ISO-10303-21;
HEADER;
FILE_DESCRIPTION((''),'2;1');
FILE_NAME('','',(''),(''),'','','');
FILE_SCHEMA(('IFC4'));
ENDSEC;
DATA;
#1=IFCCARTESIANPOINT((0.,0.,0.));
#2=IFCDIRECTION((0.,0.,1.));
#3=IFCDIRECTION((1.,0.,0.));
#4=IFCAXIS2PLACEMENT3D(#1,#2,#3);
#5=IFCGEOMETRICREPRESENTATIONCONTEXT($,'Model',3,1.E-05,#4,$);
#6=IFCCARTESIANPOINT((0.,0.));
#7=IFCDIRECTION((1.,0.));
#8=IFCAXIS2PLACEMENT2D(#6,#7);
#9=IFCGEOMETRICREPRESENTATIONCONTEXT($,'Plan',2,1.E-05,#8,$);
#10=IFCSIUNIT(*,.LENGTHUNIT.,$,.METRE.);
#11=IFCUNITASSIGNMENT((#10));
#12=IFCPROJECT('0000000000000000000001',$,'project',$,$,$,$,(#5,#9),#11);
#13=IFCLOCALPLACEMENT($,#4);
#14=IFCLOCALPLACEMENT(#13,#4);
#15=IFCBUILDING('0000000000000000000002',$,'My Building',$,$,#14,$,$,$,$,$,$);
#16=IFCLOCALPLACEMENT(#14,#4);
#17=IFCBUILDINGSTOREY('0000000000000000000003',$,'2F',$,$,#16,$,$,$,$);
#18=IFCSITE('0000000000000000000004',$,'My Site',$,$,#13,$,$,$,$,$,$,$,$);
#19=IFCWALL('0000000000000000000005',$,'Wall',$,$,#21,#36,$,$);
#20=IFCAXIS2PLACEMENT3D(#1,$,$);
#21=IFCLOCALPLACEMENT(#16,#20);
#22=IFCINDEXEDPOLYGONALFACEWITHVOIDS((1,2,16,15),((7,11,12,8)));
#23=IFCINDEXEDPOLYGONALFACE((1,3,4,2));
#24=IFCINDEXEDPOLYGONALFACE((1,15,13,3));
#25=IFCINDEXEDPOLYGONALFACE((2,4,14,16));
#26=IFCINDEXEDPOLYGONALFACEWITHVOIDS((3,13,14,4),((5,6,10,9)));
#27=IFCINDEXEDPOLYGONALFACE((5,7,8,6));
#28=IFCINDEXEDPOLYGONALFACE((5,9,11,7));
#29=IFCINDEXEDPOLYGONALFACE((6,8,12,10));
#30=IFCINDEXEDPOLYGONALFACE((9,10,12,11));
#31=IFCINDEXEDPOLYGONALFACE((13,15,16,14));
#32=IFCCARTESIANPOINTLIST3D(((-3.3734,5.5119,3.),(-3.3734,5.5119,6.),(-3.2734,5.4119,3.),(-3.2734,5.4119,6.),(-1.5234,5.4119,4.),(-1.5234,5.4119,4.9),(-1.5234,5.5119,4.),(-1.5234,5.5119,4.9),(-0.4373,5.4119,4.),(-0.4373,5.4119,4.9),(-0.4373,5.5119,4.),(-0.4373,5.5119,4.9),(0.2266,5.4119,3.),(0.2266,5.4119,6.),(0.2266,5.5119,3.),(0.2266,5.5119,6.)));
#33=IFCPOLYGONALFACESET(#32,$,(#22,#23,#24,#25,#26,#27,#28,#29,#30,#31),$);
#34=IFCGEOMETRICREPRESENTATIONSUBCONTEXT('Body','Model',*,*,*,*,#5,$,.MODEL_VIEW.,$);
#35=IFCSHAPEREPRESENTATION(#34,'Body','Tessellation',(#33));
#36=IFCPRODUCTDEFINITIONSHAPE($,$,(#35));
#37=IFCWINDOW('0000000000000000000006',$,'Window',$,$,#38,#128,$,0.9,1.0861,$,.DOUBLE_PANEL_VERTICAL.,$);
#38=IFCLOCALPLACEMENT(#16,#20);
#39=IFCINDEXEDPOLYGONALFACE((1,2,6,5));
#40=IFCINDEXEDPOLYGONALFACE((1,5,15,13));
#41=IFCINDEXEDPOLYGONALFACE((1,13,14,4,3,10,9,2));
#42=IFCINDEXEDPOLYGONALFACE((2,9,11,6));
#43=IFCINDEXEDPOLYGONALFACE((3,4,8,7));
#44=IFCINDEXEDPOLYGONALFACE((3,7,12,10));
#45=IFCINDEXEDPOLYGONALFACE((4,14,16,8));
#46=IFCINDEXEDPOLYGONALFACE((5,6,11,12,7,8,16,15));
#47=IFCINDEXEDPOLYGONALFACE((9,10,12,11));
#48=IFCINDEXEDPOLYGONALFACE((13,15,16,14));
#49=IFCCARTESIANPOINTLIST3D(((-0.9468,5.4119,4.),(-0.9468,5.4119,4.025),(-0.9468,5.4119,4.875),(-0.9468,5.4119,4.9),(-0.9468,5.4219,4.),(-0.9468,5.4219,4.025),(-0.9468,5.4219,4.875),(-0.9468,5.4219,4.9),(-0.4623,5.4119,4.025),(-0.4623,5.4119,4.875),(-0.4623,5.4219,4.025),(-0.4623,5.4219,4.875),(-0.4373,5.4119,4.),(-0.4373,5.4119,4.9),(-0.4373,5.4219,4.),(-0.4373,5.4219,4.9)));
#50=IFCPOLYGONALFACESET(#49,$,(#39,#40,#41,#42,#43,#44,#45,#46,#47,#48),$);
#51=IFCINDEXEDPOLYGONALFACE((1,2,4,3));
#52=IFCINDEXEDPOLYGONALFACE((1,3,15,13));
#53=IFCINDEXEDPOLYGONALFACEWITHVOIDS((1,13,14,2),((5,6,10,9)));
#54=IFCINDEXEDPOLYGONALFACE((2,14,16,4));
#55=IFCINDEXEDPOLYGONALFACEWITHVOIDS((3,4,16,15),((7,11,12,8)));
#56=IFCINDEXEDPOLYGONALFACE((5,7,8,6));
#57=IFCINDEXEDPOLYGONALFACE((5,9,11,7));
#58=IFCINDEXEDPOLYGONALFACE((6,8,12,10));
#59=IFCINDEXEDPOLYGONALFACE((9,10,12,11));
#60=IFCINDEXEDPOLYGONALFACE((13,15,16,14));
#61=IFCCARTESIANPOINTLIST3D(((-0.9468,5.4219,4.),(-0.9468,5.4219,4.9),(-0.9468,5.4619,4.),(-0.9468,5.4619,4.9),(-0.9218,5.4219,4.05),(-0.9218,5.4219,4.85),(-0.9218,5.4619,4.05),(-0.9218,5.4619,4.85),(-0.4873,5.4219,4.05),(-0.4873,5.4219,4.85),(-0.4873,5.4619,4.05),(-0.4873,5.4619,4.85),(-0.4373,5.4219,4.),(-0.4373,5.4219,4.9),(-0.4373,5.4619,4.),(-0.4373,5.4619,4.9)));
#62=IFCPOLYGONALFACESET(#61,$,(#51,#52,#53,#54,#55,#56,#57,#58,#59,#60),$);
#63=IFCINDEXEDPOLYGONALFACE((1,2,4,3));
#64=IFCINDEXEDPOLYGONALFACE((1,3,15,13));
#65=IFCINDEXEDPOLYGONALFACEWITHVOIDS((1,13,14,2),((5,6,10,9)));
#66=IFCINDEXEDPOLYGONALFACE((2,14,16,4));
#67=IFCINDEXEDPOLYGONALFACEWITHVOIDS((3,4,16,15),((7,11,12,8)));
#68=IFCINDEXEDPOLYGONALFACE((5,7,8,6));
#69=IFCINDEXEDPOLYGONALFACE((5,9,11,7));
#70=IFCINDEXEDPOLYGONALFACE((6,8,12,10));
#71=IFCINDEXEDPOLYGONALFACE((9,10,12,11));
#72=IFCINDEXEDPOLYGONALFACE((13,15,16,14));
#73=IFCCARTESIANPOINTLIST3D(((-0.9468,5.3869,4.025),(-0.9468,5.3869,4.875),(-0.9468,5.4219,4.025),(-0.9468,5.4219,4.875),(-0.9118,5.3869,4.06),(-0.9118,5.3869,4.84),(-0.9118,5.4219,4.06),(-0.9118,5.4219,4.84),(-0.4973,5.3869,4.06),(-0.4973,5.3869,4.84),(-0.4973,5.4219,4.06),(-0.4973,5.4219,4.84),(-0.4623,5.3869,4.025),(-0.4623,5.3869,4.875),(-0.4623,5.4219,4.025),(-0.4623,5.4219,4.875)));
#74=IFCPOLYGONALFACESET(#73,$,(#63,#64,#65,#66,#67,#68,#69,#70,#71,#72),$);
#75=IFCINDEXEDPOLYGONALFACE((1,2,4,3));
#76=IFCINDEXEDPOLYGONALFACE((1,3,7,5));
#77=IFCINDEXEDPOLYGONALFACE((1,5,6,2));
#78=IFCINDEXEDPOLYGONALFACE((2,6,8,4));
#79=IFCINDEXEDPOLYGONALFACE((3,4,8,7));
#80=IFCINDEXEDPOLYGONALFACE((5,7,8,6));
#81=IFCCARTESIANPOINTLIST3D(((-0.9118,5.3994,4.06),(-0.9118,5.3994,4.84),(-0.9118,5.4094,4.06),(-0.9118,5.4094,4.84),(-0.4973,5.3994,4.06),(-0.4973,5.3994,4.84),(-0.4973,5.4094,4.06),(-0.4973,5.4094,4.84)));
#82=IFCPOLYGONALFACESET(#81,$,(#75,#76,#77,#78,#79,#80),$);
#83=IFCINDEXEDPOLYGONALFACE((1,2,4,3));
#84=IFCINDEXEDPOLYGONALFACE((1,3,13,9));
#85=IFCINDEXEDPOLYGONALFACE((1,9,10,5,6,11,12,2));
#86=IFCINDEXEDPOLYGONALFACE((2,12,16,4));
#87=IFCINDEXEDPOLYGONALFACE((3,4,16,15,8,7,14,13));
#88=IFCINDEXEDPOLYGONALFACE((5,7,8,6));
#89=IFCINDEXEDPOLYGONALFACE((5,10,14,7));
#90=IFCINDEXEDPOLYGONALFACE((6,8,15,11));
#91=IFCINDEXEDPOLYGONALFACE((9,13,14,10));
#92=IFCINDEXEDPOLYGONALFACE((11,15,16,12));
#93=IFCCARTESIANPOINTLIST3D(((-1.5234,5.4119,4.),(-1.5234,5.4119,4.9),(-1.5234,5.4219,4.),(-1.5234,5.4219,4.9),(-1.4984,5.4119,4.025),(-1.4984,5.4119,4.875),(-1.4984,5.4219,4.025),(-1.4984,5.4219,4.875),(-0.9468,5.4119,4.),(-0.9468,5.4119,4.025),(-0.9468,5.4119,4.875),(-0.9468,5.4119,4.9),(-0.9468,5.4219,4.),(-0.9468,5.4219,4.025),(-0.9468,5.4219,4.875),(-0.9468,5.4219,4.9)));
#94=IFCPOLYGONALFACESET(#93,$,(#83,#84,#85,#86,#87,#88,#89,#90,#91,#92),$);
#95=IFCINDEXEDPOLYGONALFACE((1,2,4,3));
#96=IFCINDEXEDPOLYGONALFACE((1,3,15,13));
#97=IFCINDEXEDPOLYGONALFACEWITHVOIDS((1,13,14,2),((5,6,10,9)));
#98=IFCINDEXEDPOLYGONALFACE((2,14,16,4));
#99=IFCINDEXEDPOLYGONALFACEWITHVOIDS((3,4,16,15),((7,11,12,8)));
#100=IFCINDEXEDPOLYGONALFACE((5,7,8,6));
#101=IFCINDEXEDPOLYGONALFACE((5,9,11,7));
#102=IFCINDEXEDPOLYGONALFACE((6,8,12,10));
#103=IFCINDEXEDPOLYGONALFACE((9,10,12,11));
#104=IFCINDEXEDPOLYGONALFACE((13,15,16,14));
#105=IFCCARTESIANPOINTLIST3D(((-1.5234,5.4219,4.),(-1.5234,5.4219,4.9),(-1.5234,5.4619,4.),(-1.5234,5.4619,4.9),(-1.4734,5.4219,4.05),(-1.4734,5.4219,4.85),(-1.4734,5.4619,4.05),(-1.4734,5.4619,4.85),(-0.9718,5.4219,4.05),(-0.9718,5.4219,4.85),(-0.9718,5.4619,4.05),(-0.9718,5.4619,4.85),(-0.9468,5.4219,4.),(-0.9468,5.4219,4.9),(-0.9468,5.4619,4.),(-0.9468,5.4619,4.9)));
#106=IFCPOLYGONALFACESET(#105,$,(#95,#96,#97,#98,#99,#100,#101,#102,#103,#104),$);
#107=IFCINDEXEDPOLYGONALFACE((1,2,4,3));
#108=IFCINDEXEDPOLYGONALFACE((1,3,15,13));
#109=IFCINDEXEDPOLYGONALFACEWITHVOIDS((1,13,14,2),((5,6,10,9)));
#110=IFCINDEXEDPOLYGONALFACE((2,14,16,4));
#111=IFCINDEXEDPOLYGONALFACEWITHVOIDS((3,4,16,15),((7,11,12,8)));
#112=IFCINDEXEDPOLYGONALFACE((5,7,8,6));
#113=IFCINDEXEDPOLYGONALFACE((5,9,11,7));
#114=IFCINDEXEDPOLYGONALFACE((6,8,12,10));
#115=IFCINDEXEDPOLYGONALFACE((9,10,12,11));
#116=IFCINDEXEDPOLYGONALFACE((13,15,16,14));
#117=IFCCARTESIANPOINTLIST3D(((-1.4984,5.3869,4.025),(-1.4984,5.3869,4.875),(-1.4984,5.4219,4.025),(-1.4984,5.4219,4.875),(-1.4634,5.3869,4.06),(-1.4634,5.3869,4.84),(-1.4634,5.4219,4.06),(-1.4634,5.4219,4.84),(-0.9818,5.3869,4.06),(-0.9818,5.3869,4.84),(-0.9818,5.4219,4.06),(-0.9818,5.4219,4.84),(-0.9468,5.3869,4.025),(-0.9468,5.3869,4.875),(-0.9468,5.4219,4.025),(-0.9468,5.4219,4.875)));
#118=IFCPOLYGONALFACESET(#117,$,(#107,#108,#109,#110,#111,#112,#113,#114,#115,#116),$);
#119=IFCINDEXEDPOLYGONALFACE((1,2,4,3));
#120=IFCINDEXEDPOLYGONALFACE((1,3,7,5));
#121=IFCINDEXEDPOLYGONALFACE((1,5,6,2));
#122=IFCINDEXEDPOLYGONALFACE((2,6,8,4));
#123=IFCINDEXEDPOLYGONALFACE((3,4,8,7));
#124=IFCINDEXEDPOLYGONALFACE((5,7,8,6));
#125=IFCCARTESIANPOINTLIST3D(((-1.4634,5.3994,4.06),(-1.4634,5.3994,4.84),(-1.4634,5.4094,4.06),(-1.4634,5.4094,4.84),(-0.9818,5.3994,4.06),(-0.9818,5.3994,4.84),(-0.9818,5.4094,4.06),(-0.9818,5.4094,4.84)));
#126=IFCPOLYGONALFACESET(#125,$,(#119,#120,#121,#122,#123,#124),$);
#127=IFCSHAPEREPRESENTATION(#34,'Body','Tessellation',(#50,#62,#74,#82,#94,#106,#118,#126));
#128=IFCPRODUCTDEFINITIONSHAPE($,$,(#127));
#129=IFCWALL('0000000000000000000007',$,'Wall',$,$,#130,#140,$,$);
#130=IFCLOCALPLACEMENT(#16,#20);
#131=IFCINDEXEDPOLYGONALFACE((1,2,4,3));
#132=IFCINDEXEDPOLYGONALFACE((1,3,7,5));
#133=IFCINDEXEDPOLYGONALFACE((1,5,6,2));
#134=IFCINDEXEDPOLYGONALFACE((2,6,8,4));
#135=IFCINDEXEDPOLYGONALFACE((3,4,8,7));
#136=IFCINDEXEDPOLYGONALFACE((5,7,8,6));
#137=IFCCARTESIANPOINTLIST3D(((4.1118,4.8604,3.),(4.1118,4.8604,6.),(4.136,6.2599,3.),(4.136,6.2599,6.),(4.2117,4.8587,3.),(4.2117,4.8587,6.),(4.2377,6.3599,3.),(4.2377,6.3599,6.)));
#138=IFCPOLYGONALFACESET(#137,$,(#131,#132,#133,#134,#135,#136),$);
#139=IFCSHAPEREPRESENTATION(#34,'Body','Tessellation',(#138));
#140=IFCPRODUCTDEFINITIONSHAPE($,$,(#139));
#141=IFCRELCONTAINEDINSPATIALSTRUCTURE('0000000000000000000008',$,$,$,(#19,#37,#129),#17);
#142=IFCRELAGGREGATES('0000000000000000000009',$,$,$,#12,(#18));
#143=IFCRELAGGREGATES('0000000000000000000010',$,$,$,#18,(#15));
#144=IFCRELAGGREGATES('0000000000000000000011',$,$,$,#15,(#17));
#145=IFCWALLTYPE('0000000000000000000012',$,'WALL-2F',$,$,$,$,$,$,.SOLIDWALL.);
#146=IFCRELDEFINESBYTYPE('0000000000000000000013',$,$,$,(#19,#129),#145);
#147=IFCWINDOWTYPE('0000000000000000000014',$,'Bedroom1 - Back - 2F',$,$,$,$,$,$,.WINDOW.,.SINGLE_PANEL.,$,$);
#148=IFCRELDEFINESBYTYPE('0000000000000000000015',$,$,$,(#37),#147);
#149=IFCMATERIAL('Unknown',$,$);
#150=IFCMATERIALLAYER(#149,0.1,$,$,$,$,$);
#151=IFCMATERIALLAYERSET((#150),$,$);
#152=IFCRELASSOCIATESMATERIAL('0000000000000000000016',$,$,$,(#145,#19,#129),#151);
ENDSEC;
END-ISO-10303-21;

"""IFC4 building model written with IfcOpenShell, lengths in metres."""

from ifc_helpers import new_model, entity, si_unit, frame, origin_with_axes, origin_2d_with_axis, place, context, subcontext, project, spatial, line, indexed_curve, outline, extrude, shape, source, transform, mapped, material, layer, layer_set, layer_usage, type_object, type_shapes, element, fill, save


model = new_model("IFC4")

# Units and contexts
model_context = context("Model", 3, precision=1e-05, world=origin_with_axes())
plan_context = context("Plan", 2, precision=1e-05, world=origin_2d_with_axis())
body_context_1 = subcontext(model_context, "Body", "Model", "MODEL_VIEW")
body_context_2 = subcontext(plan_context, "Body", "Plan", "PLAN_VIEW")
ifc_project = project(units=[si_unit("LENGTHUNIT", "METRE")], contexts=[model_context, plan_context])

# Site, building, storey
site_placement = place(None, origin_with_axes())
site = spatial("IfcSite", under=ifc_project, at=site_placement, Name="My Site")
building_placement = place(site_placement, origin_with_axes())
building = spatial("IfcBuilding", under=site, at=building_placement, Name="My Building")
storey_placement = place(building_placement, origin_with_axes())
storey = spatial("IfcBuildingStorey", under=building, at=storey_placement, Name="2F")

# Shared definitions
ifc_material = material(Name="Unknown")

# Shared definitions
ifc_layer = layer(ifc_material, 0.1)
ifc_layer_set = layer_set([ifc_layer])
wall_type = type_object("IfcWallType", Name="WALL-2F", PredefinedType="SOLIDWALL", material=ifc_layer_set)

# Wall, opening, window
ifc_layer_usage_1 = layer_usage(ifc_layer_set, "AXIS2", "POSITIVE", 0.0)
wall_1_placement = place(storey_placement, frame((0.2266, 5.5119, 3.0), z_axis=(0.0, 0.0, 1.0), x_axis=(-1.0, 0.0, 0.0)))
wall_1 = element("IfcWall", 1, at=wall_1_placement, inside=storey, type_object=wall_type, material=ifc_layer_usage_1, Name="Wall", context=body_context_1, shape_type="SweptSolid", body=[
    extrude(outline(indexed_curve([(0.0, 0.0), (0.0, 0.1), (3.5, 0.1), (3.6, 0.0)], segments=[line(1, 2, 3, 4, 1)])), origin_with_axes(), (0.0, 0.0, 1.0), 3.0),
])
shared_shape_1 = source(origin_with_axes(), body_context_1, "Body", "SweptSolid", [
    extrude(outline(indexed_curve([(0.0, 0.0), (1.0861, 0.0), (1.0861, 0.9), (0.0, 0.9)], segments=[line(1, 2, 3, 4, 1)])), frame((0.0, -0.6, 0.0), z_axis=(0.0, -1.0, 0.0), x_axis=(1.0, 0.0, 0.0)), (0.0, 0.0, -1.0), 1.2),
])
opening_1_placement = place(wall_1_placement, frame((0.6639, 0.0, 1.0), z_axis=(0.0, 0.0, 1.0), x_axis=(1.0, 0.0, 0.0)))
opening_1 = element("IfcOpeningElement", 2, at=opening_1_placement, cuts=wall_1, PredefinedType="OPENING", context=body_context_1, shape_type="MappedRepresentation", body=[
    mapped(shared_shape_1, transform((0.0, 0.0, 0.0), x_axis=(1.0, 0.0, 0.0), y_axis=(0.0, 1.0, 0.0), z_axis=(0.0, 0.0, 1.0), scale=1.0)),
])
window_type_1 = type_object("IfcWindowType", Name="Bedroom1 - Back - 2F", PartitioningType="SINGLE_PANEL", PredefinedType="WINDOW")
shared_shape_2 = source(origin_with_axes(), body_context_1, "Body", "SweptSolid", [
    extrude(outline(indexed_curve([(0.5096, 0.0), (0.0, 0.0), (0.0, 0.9), (0.5096, 0.9), (0.5096, 0.875), (0.025, 0.875), (0.025, 0.025), (0.5096, 0.025)], segments=[line(1, 2, 3, 4, 5, 6, 7, 8, 1)])), frame((0.0, 0.09, 0.0), z_axis=(0.0, -1.0, 0.0), x_axis=(1.0, 0.0, 0.0)), (0.0, 0.0, -1.0), 0.01),
    extrude(outline(indexed_curve([(0.0, 0.0), (0.5096, 0.0), (0.5096, 0.9), (0.0, 0.9)], segments=[line(1, 2, 3, 4, 1)]), holes=[indexed_curve([(0.05, 0.05), (0.4846, 0.05), (0.4846, 0.85), (0.05, 0.85)], segments=[line(1, 2, 3, 4, 1)])]), frame((0.0, 0.05, 0.0), z_axis=(0.0, -1.0, 0.0), x_axis=(1.0, 0.0, 0.0)), (0.0, 0.0, -1.0), 0.04),
    extrude(outline(indexed_curve([(0.0, 0.0), (0.4846, 0.0), (0.4846, 0.85), (0.0, 0.85)], segments=[line(1, 2, 3, 4, 1)]), holes=[indexed_curve([(0.035, 0.035), (0.4496, 0.035), (0.4496, 0.815), (0.035, 0.815)], segments=[line(1, 2, 3, 4, 1)])]), frame((0.025, 0.09, 0.025), z_axis=(0.0, -1.0, 0.0), x_axis=(1.0, 0.0, 0.0)), (0.0, 0.0, -1.0), 0.035),
    extrude(outline(indexed_curve([(0.035, 0.035), (0.4496, 0.035), (0.4496, 0.815), (0.035, 0.815)], segments=[line(1, 2, 3, 4, 1)])), frame((0.025, 0.1025, 0.025), z_axis=(0.0, -1.0, 0.0), x_axis=(1.0, 0.0, 0.0)), (0.0, 0.0, -1.0), 0.01),
    extrude(outline(indexed_curve([(0.0, 0.9), (0.5766, 0.9), (0.5766, 0.0), (0.0, 0.0), (0.0, 0.025), (0.5516, 0.025), (0.5516, 0.875), (0.0, 0.875)], segments=[line(1, 2, 3, 4, 5, 6, 7, 8, 1)])), frame((0.5096, 0.09, 0.0), z_axis=(0.0, -1.0, 0.0), x_axis=(1.0, 0.0, 0.0)), (0.0, 0.0, -1.0), 0.01),
    extrude(outline(indexed_curve([(0.0, 0.0), (0.5766, 0.0), (0.5766, 0.9), (0.0, 0.9)], segments=[line(1, 2, 3, 4, 1)]), holes=[indexed_curve([(0.025, 0.05), (0.5266, 0.05), (0.5266, 0.85), (0.025, 0.85)], segments=[line(1, 2, 3, 4, 1)])]), frame((0.5096, 0.05, 0.0), z_axis=(0.0, -1.0, 0.0), x_axis=(1.0, 0.0, 0.0)), (0.0, 0.0, -1.0), 0.04),
    extrude(outline(indexed_curve([(0.0, 0.0), (0.5516, 0.0), (0.5516, 0.85), (0.0, 0.85)], segments=[line(1, 2, 3, 4, 1)]), holes=[indexed_curve([(0.035, 0.035), (0.5166, 0.035), (0.5166, 0.815), (0.035, 0.815)], segments=[line(1, 2, 3, 4, 1)])]), frame((0.5096, 0.09, 0.025), z_axis=(0.0, -1.0, 0.0), x_axis=(1.0, 0.0, 0.0)), (0.0, 0.0, -1.0), 0.035),
    extrude(outline(indexed_curve([(0.035, 0.035), (0.5166, 0.035), (0.5166, 0.815), (0.035, 0.815)], segments=[line(1, 2, 3, 4, 1)])), frame((0.5096, 0.1025, 0.025), z_axis=(0.0, -1.0, 0.0), x_axis=(1.0, 0.0, 0.0)), (0.0, 0.0, -1.0), 0.01),
])
shared_shape_3 = source(origin_with_axes(), body_context_2, "Body", "Curve2D", [
    entity("IfcIndexedPolyCurve", entity("IfcCartesianPointList2D", [[0.05, 0.05], [0.4846, 0.05]])),
    entity("IfcIndexedPolyCurve", entity("IfcCartesianPointList2D", [[0.0, 0.1], [0.025, 0.1], [0.025, 0.09], [0.05, 0.09], [0.05, 0.05], [0.0, 0.05]]), [entity("IfcLineIndex", [1, 2, 3, 4, 5, 6, 1])]),
    entity("IfcIndexedPolyCurve", entity("IfcCartesianPointList2D", [[0.5096, 0.1], [0.5096, 0.1], [0.5096, 0.09], [0.4846, 0.09], [0.4846, 0.05], [0.5096, 0.05]])),
    entity("IfcIndexedPolyCurve", entity("IfcCartesianPointList2D", [[0.025, 0.09], [0.06, 0.09], [0.06, 0.125], [0.025, 0.125]]), [entity("IfcLineIndex", [1, 2, 3, 4, 1])]),
    entity("IfcIndexedPolyCurve", entity("IfcCartesianPointList2D", [[0.5096, 0.09], [0.4746, 0.09], [0.4746, 0.125], [0.5096, 0.125]]), [entity("IfcLineIndex", [1, 2, 3, 4, 1])]),
    entity("IfcIndexedPolyCurve", entity("IfcCartesianPointList2D", [[0.06, 0.09], [0.4746, 0.09]])),
    entity("IfcIndexedPolyCurve", entity("IfcCartesianPointList2D", [[0.06, 0.125], [0.4746, 0.125]])),
    entity("IfcIndexedPolyCurve", entity("IfcCartesianPointList2D", [[0.06, 0.1075], [0.4746, 0.1075]])),
    entity("IfcIndexedPolyCurve", entity("IfcCartesianPointList2D", [[0.5346, 0.05], [1.0361, 0.05]])),
    entity("IfcIndexedPolyCurve", entity("IfcCartesianPointList2D", [[0.5096, 0.1], [0.5096, 0.1], [0.5096, 0.09], [0.5346, 0.09], [0.5346, 0.05], [0.5096, 0.05]])),
    entity("IfcIndexedPolyCurve", entity("IfcCartesianPointList2D", [[1.0861, 0.1], [1.0611, 0.1], [1.0611, 0.09], [1.0361, 0.09], [1.0361, 0.05], [1.0861, 0.05]]), [entity("IfcLineIndex", [1, 2, 3, 4, 5, 6, 1])]),
    entity("IfcIndexedPolyCurve", entity("IfcCartesianPointList2D", [[0.5096, 0.09], [0.5446, 0.09], [0.5446, 0.125], [0.5096, 0.125]]), [entity("IfcLineIndex", [1, 2, 3, 4, 1])]),
    entity("IfcIndexedPolyCurve", entity("IfcCartesianPointList2D", [[1.0611, 0.09], [1.0261, 0.09], [1.0261, 0.125], [1.0611, 0.125]]), [entity("IfcLineIndex", [1, 2, 3, 4, 1])]),
    entity("IfcIndexedPolyCurve", entity("IfcCartesianPointList2D", [[0.5446, 0.09], [1.0261, 0.09]])),
    entity("IfcIndexedPolyCurve", entity("IfcCartesianPointList2D", [[0.5446, 0.125], [1.0261, 0.125]])),
    entity("IfcIndexedPolyCurve", entity("IfcCartesianPointList2D", [[0.5446, 0.1075], [1.0261, 0.1075]])),
])
type_shapes(window_type_1, [shared_shape_2, shared_shape_3])
window_1_placement = place(opening_1_placement, frame((0.0, 0.0, 0.0), z_axis=(0.0, 0.0, 1.0), x_axis=(1.0, 0.0, 0.0)))
window_1 = element("IfcWindow", 3, at=window_1_placement, inside=storey, type_object=window_type_1, Name="Window", OverallHeight=0.9, OverallWidth=1.0861, PartitioningType="DOUBLE_PANEL_VERTICAL", shapes=[
    shape(body_context_1, "Body", "MappedRepresentation", [mapped(shared_shape_2, transform((0.0, 0.0, 0.0), x_axis=(1.0, 0.0, 0.0), y_axis=(0.0, 1.0, 0.0), z_axis=(0.0, 0.0, 1.0), scale=1.0))]),
    shape(body_context_2, "Body", "MappedRepresentation", [mapped(shared_shape_3, transform((0.0, 0.0, 0.0), x_axis=(1.0, 0.0, 0.0), y_axis=(0.0, 1.0, 0.0), z_axis=(0.0, 0.0, 1.0), scale=1.0))]),
])
fill(opening_1, window_1)

# Wall
ifc_layer_usage_2 = layer_usage(ifc_layer_set, "AXIS2", "POSITIVE", 0.0)
wall_2_placement = place(storey_placement, frame((4.2117, 4.8587, 3.0), z_axis=(0.0, 0.0, 1.0), x_axis=(0.0173, 0.99985, 0.0)))
element("IfcWall", 4, at=wall_2_placement, inside=storey, type_object=wall_type, material=ifc_layer_usage_2, Name="Wall", context=body_context_1, shape_type="SweptSolid", body=[
    extrude(outline(indexed_curve([(0.0, 0.0), (0.0, 0.1), (1.3997, 0.1), (1.5015, 0.0)], segments=[line(1, 2, 3, 4, 1)])), origin_with_axes(), (0.0, 0.0, 1.0), 3.0),
])

save(model, "model.ifc")
